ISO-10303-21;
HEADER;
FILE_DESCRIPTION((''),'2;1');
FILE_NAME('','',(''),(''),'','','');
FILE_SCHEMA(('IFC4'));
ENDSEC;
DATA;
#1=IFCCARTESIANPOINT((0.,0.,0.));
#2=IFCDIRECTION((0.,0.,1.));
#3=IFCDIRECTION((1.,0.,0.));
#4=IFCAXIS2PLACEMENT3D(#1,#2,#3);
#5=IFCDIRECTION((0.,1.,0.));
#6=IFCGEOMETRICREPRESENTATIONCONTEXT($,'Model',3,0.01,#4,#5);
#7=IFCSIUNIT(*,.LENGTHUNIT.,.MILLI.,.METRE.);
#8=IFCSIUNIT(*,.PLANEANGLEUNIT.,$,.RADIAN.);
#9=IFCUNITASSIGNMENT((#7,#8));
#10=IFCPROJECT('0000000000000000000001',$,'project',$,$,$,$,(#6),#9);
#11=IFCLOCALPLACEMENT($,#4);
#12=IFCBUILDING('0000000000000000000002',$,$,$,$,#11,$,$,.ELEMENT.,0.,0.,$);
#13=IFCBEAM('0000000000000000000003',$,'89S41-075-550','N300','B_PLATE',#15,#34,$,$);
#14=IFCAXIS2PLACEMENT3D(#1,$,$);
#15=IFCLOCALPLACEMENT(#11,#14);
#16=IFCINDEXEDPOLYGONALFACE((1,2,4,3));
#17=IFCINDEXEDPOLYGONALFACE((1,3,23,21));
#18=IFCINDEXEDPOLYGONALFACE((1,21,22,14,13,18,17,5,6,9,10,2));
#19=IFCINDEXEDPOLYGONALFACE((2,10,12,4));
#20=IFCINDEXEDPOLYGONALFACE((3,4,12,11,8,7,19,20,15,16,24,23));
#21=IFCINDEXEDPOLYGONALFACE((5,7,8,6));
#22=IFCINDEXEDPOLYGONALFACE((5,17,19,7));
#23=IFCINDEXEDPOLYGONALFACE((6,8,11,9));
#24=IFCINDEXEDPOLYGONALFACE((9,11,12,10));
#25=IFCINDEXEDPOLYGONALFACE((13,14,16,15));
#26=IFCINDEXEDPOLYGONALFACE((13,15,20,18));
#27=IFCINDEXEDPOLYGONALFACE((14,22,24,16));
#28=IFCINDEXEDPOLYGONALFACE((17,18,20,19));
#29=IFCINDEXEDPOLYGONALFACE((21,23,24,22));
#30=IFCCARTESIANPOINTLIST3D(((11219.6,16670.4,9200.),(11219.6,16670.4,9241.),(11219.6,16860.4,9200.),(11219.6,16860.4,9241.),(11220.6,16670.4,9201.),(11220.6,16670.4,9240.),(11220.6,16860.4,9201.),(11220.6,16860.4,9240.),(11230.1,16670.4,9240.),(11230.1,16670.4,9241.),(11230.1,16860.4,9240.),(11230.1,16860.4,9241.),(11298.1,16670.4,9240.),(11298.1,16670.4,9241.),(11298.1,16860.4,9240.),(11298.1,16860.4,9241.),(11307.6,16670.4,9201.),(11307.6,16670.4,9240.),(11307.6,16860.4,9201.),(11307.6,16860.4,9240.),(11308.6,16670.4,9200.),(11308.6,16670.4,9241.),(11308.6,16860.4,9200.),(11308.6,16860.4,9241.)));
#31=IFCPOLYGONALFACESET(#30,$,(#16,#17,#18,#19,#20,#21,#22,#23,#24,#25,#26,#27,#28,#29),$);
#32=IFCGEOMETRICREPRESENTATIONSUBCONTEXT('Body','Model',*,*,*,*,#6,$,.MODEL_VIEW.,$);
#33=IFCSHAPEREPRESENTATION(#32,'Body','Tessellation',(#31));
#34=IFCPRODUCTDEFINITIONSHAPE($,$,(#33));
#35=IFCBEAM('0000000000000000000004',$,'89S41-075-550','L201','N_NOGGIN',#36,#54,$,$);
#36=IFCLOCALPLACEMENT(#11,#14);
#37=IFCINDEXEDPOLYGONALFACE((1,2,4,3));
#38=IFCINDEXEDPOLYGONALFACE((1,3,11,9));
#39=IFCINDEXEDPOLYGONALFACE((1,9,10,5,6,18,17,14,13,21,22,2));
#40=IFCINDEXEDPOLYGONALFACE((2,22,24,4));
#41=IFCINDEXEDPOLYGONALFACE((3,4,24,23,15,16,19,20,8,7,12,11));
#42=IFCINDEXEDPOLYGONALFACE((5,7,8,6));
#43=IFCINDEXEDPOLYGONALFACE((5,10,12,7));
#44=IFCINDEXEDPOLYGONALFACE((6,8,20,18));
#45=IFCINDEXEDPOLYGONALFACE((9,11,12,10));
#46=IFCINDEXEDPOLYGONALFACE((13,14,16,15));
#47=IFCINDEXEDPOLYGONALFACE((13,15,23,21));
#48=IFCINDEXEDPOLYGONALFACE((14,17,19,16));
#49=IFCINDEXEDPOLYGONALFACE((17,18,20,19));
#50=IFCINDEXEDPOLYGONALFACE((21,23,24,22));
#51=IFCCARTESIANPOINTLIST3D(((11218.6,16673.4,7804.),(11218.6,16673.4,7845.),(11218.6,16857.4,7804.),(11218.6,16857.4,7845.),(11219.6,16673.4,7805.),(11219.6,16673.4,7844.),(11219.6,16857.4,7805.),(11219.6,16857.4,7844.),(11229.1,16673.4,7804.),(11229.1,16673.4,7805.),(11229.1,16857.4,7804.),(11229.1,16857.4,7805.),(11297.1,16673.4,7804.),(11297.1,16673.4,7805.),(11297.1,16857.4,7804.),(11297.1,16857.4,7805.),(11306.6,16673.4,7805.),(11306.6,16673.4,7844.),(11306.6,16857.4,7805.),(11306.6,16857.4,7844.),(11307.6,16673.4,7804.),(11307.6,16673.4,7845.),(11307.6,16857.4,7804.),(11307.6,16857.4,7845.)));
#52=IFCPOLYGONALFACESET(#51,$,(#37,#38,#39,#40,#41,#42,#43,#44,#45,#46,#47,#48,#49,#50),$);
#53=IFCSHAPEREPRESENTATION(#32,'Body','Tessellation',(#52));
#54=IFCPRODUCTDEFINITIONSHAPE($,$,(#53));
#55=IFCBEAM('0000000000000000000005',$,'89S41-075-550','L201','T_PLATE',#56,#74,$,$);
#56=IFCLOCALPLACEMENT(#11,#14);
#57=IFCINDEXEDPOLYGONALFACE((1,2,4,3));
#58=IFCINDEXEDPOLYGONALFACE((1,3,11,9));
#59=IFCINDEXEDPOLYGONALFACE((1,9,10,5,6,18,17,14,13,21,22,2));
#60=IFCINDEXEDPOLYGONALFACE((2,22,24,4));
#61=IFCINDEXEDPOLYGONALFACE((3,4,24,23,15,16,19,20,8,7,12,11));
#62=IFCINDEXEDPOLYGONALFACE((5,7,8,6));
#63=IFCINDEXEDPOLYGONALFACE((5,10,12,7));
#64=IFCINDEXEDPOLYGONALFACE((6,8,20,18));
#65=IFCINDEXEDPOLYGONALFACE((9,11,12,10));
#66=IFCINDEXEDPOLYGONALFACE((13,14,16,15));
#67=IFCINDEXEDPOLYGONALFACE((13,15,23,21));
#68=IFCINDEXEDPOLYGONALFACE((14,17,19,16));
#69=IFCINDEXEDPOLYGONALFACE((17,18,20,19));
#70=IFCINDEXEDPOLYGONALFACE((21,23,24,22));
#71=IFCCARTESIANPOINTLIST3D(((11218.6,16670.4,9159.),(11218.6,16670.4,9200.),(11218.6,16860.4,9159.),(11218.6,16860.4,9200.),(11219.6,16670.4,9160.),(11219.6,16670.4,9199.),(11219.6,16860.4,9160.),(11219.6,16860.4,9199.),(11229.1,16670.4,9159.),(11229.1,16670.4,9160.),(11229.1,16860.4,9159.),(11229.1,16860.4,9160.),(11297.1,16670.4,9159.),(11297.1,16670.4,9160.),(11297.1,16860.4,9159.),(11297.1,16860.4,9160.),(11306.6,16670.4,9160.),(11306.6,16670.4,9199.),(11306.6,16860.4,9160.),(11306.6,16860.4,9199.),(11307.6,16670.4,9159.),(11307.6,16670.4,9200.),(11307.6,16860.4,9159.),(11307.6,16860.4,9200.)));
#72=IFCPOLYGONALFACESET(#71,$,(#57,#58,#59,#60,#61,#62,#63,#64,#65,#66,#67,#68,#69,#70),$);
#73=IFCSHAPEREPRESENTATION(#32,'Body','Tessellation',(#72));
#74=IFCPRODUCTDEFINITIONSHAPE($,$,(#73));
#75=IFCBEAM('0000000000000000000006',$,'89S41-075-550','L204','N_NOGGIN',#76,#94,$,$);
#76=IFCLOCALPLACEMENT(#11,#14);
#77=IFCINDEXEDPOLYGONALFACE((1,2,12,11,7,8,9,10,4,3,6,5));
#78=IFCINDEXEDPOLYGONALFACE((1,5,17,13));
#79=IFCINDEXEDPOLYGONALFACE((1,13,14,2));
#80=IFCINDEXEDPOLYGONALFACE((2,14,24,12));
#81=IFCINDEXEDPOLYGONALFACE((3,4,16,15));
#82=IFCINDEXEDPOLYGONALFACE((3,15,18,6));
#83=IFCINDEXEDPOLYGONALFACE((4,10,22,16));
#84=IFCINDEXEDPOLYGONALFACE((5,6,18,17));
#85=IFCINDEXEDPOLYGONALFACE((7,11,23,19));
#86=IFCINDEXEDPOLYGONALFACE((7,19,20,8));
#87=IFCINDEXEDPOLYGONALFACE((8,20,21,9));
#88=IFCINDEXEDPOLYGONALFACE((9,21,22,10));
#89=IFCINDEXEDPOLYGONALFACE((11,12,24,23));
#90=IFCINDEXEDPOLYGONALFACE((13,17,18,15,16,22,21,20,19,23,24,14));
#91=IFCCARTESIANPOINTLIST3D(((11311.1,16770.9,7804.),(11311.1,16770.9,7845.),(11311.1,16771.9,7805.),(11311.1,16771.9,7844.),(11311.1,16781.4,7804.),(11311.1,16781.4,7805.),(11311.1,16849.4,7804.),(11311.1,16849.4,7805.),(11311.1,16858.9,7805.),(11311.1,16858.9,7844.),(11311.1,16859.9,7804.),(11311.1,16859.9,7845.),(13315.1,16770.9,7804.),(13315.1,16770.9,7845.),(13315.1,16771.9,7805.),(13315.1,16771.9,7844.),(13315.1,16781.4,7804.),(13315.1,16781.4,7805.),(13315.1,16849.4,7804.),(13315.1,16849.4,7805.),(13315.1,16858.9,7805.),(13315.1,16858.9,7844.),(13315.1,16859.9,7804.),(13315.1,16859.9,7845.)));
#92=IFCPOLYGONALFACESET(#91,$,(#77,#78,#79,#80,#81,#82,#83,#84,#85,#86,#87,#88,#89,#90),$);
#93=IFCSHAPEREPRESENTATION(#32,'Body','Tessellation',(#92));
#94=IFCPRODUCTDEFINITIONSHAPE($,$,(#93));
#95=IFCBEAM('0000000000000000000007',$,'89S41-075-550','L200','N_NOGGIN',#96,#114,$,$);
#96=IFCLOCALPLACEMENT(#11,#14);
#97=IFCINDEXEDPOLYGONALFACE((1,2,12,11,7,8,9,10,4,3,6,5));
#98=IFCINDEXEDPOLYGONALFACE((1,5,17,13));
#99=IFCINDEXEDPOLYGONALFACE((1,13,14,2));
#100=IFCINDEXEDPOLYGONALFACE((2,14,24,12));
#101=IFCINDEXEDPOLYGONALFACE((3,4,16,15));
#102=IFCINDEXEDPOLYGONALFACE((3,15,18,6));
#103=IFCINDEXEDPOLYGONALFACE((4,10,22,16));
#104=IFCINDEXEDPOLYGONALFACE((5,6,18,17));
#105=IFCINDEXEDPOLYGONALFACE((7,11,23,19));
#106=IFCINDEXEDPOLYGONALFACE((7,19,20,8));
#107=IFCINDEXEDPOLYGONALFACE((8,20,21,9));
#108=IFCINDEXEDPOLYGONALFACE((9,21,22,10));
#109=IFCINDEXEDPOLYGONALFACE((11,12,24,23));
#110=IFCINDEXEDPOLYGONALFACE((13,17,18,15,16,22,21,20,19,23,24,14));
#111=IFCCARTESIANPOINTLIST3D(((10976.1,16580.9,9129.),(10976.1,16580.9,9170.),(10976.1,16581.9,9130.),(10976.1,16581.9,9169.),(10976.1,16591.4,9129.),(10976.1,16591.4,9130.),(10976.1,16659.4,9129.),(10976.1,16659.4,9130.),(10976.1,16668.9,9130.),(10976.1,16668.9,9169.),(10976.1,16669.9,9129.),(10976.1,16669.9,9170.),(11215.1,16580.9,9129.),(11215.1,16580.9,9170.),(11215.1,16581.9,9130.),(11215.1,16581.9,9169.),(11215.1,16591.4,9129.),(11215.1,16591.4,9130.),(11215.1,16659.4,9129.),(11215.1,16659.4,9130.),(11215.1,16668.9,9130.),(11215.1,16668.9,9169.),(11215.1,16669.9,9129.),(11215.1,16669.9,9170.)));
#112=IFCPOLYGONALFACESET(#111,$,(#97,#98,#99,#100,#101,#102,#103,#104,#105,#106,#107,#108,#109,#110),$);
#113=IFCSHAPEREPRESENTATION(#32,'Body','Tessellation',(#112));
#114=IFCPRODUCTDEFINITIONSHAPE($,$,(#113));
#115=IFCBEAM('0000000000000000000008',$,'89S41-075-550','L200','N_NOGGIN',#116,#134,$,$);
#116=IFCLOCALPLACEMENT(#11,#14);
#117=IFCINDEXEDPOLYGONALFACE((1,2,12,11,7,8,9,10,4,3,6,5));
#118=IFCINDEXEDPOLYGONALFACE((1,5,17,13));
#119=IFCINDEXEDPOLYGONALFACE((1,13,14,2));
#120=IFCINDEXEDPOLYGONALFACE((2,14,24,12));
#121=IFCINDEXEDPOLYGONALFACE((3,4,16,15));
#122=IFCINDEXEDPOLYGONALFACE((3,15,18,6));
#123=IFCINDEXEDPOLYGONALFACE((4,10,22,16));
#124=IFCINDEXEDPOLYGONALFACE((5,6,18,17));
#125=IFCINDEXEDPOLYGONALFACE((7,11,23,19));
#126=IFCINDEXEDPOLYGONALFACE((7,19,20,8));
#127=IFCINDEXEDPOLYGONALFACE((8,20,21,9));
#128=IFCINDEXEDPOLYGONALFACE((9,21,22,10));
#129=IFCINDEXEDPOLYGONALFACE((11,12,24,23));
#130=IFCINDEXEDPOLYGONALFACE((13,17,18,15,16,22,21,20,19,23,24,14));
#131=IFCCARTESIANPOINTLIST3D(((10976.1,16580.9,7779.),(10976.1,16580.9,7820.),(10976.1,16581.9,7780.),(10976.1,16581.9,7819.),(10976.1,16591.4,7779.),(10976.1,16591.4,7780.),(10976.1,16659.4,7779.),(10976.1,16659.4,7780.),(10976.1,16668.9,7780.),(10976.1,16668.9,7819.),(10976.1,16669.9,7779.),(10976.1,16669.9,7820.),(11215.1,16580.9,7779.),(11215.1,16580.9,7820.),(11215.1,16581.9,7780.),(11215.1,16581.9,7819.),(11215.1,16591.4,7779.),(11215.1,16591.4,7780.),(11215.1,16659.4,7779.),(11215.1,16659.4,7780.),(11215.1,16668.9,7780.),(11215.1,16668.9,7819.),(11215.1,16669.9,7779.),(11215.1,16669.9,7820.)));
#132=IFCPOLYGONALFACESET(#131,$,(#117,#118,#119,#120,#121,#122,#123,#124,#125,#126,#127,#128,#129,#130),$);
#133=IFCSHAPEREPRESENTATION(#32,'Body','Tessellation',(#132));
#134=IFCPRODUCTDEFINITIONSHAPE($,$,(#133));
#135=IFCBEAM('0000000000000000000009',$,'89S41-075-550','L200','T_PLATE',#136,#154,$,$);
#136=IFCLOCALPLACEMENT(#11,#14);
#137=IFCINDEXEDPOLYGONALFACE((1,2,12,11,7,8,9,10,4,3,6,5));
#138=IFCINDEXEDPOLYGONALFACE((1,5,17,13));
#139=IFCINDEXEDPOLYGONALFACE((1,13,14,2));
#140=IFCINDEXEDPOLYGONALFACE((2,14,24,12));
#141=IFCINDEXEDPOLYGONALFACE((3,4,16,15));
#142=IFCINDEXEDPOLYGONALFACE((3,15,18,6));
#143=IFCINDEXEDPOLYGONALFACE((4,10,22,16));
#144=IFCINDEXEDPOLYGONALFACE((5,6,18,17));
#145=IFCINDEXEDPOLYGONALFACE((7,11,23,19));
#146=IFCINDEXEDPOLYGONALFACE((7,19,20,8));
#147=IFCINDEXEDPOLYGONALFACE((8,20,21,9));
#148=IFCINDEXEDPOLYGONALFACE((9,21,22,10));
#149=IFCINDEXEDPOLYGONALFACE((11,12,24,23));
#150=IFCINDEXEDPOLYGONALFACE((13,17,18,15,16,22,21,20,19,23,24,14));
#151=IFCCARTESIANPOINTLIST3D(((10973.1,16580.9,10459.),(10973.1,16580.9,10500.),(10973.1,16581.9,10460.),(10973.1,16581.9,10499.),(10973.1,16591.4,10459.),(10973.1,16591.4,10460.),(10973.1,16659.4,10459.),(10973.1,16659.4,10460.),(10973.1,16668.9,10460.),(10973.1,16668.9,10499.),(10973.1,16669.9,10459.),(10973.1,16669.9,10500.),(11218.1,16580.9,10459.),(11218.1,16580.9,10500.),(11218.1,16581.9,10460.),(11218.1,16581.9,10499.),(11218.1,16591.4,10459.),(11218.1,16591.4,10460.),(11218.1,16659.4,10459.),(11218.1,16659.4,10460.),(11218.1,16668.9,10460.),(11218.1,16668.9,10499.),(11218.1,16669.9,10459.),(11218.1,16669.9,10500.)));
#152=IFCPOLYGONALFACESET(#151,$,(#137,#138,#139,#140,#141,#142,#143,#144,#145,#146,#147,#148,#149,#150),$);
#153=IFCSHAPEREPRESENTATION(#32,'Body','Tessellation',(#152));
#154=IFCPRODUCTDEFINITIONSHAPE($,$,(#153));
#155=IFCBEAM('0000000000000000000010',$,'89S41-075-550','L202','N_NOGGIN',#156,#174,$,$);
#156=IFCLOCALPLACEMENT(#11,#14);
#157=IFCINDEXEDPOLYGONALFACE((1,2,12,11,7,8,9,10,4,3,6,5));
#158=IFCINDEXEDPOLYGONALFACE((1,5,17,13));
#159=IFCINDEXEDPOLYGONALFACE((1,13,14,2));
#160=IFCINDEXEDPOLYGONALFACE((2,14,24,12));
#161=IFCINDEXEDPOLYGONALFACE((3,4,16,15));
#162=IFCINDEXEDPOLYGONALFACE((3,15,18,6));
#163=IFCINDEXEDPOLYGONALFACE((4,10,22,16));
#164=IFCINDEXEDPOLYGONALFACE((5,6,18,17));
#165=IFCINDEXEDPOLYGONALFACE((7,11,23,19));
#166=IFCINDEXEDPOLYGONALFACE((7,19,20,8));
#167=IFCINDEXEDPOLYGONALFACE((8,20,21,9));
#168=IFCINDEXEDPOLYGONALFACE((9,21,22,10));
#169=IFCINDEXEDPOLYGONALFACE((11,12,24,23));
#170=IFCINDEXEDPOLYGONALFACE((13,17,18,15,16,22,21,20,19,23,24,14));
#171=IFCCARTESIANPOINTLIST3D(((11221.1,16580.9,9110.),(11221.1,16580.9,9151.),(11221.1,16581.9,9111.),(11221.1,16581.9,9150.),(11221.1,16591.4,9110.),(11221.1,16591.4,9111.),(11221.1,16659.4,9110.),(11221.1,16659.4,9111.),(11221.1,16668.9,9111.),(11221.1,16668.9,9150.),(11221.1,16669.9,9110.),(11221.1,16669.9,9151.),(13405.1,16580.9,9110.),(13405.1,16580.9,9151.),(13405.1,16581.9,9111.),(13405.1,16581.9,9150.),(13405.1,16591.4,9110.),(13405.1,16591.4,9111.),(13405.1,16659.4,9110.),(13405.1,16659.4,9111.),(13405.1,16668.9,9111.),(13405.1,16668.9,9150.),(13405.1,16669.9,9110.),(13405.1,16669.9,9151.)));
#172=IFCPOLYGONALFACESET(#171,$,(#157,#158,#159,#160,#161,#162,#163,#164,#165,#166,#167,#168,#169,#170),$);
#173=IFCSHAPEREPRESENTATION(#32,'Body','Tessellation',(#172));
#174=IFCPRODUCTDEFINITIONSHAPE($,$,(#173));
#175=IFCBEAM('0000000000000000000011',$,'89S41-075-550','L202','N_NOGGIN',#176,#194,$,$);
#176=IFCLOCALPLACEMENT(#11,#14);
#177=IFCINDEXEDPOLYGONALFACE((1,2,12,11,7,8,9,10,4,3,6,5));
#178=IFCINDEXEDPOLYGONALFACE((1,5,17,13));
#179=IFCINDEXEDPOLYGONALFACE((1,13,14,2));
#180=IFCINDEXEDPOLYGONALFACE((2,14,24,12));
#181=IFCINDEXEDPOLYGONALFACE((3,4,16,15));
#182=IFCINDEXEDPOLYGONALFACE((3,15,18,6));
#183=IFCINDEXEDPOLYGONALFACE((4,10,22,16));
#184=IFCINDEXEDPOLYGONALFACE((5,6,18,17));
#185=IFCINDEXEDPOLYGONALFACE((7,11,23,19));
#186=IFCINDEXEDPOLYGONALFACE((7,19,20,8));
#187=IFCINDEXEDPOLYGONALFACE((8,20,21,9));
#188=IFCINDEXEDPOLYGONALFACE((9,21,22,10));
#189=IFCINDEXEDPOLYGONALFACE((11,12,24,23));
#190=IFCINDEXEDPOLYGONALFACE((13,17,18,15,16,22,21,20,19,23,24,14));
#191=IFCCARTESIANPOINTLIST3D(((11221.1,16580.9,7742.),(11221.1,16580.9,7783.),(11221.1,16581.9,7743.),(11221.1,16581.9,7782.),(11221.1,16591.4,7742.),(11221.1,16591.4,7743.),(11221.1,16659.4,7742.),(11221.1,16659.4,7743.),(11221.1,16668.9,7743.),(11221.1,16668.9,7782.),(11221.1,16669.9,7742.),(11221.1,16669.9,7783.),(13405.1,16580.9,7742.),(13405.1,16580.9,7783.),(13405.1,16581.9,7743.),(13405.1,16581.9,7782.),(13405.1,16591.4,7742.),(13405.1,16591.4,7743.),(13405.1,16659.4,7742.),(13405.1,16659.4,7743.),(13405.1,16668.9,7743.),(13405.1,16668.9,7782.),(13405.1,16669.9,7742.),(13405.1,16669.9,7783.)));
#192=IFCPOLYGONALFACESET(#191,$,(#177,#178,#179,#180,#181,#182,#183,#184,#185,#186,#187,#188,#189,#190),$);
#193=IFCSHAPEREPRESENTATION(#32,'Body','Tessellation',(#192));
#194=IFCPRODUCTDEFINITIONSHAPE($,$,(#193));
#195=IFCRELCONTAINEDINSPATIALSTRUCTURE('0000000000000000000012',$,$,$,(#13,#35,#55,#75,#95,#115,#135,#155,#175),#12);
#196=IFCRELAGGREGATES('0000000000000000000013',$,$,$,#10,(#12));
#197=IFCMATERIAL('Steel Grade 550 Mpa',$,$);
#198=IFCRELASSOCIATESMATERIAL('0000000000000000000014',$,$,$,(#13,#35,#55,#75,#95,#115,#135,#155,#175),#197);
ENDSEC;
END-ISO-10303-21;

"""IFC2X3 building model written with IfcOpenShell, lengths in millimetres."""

from ifc_helpers import new_model, si_unit, direction, frame, origin, origin_with_axes, origin_2d_with_axis, place, context, subcontext, project, spatial, c_section, extrude, source, transform, mapped, material, element, save


model = new_model("IFC2X3")

# Units and contexts
model_context = context("Model", 3, precision=0.01, world=origin_with_axes(), true_north=direction((0.0, 1.0, 0.0)))
body_context = subcontext(model_context, "Body", "Model", "MODEL_VIEW")
ifc_project = project(units=[si_unit("LENGTHUNIT", "METRE", prefix="MILLI"), si_unit("PLANEANGLEUNIT", "RADIAN")], contexts=[model_context])

# Building
building_placement = place(None, origin_with_axes())
building = spatial("IfcBuilding", under=ifc_project, at=building_placement, CompositionType="ELEMENT", ElevationOfRefHeight=0.0, ElevationOfTerrain=0.0)

# Shared definitions
ifc_material_1 = material(Name="Steel Grade 550 Mpa")

# Beams
shared_shape_1 = source(origin(), body_context, "Body", "SweptSolid", [
    extrude(c_section(Depth=89.0, Width=41.0, WallThickness=1.0, Girth=10.5, at=origin_2d_with_axis()), origin_with_axes(), (0.0, 0.0, 1.0), 190.0),
])
beam_1_placement = place(None, frame((11264.1, 16860.4, 9220.5), z_axis=(0.0, -1.0, 0.0), x_axis=(0.0, 0.0, 1.0)))
element("IfcBeam", 1, at=beam_1_placement, inside=building, material=ifc_material_1, Name="89S41-075-550", Description="N300", ObjectType="B_PLATE", context=body_context, shape_type="MappedRepresentation", body=[
    mapped(shared_shape_1, transform((0.0, 0.0, 0.0), scale=1.0)),
])
shared_shape_2 = source(origin(), body_context, "Body", "SweptSolid", [
    extrude(c_section(Depth=89.0, Width=41.0, WallThickness=1.0, Girth=10.5, at=origin_2d_with_axis()), origin_with_axes(), (0.0, 0.0, 1.0), 184.0),
])
beam_2_placement = place(None, frame((11263.1, 16857.4, 7824.5), z_axis=(0.0, -1.0, 0.0), x_axis=(0.0, 0.0, -1.0)))
element("IfcBeam", 2, at=beam_2_placement, inside=building, material=ifc_material_1, Name="89S41-075-550", Description="L201", ObjectType="N_NOGGIN", context=body_context, shape_type="MappedRepresentation", body=[
    mapped(shared_shape_2, transform((0.0, 0.0, 0.0), scale=1.0)),
])
shared_shape_3 = source(origin(), body_context, "Body", "SweptSolid", [
    extrude(c_section(Depth=89.0, Width=41.0, WallThickness=1.0, Girth=10.5, at=origin_2d_with_axis()), origin_with_axes(), (0.0, 0.0, 1.0), 190.0),
])
beam_3_placement = place(None, frame((11263.1, 16860.4, 9179.5), z_axis=(0.0, -1.0, 0.0), x_axis=(0.0, 0.0, -1.0)))
element("IfcBeam", 3, at=beam_3_placement, inside=building, material=ifc_material_1, Name="89S41-075-550", Description="L201", ObjectType="T_PLATE", context=body_context, shape_type="MappedRepresentation", body=[
    mapped(shared_shape_3, transform((0.0, 0.0, 0.0), scale=1.0)),
])
shared_shape_4 = source(origin(), body_context, "Body", "SweptSolid", [
    extrude(c_section(Depth=89.0, Width=41.0, WallThickness=1.0, Girth=10.5, at=origin_2d_with_axis()), origin_with_axes(), (0.0, 0.0, 1.0), 2004.0),
])
beam_4_placement = place(None, frame((13315.1, 16815.4, 7824.5), z_axis=(-1.0, 0.0, 0.0), x_axis=(0.0, 0.0, -1.0)))
element("IfcBeam", 4, at=beam_4_placement, inside=building, material=ifc_material_1, Name="89S41-075-550", Description="L204", ObjectType="N_NOGGIN", context=body_context, shape_type="MappedRepresentation", body=[
    mapped(shared_shape_4, transform((0.0, 0.0, 0.0), scale=1.0)),
])
shared_shape_5 = source(origin(), body_context, "Body", "SweptSolid", [
    extrude(c_section(Depth=89.0, Width=41.0, WallThickness=1.0, Girth=10.5, at=origin_2d_with_axis()), origin_with_axes(), (0.0, 0.0, 1.0), 239.0),
])
beam_5_placement = place(None, frame((10976.1, 16625.4, 9149.5), z_axis=(1.0, 0.0, 0.0), x_axis=(0.0, 0.0, -1.0)))
element("IfcBeam", 5, at=beam_5_placement, inside=building, material=ifc_material_1, Name="89S41-075-550", Description="L200", ObjectType="N_NOGGIN", context=body_context, shape_type="MappedRepresentation", body=[
    mapped(shared_shape_5, transform((0.0, 0.0, 0.0), scale=1.0)),
])
shared_shape_6 = source(origin(), body_context, "Body", "SweptSolid", [
    extrude(c_section(Depth=89.0, Width=41.0, WallThickness=1.0, Girth=10.5, at=origin_2d_with_axis()), origin_with_axes(), (0.0, 0.0, 1.0), 239.0),
])
beam_6_placement = place(None, frame((10976.1, 16625.4, 7799.5), z_axis=(1.0, 0.0, 0.0), x_axis=(0.0, 0.0, -1.0)))
element("IfcBeam", 6, at=beam_6_placement, inside=building, material=ifc_material_1, Name="89S41-075-550", Description="L200", ObjectType="N_NOGGIN", context=body_context, shape_type="MappedRepresentation", body=[
    mapped(shared_shape_6, transform((0.0, 0.0, 0.0), scale=1.0)),
])
shared_shape_7 = source(origin(), body_context, "Body", "SweptSolid", [
    extrude(c_section(Depth=89.0, Width=41.0, WallThickness=1.0, Girth=10.5, at=origin_2d_with_axis()), origin_with_axes(), (0.0, 0.0, 1.0), 245.0),
])
beam_7_placement = place(None, frame((10973.1, 16625.4, 10479.5), z_axis=(1.0, 0.0, 0.0), x_axis=(0.0, 0.0, -1.0)))
element("IfcBeam", 7, at=beam_7_placement, inside=building, material=ifc_material_1, Name="89S41-075-550", Description="L200", ObjectType="T_PLATE", context=body_context, shape_type="MappedRepresentation", body=[
    mapped(shared_shape_7, transform((0.0, 0.0, 0.0), scale=1.0)),
])
shared_shape_8 = source(origin(), body_context, "Body", "SweptSolid", [
    extrude(c_section(Depth=89.0, Width=41.0, WallThickness=1.0, Girth=10.5, at=origin_2d_with_axis()), origin_with_axes(), (0.0, 0.0, 1.0), 2184.0),
])
beam_8_placement = place(None, frame((11221.1, 16625.4, 9130.5), z_axis=(1.0, 0.0, 0.0), x_axis=(0.0, 0.0, -1.0)))
element("IfcBeam", 8, at=beam_8_placement, inside=building, material=ifc_material_1, Name="89S41-075-550", Description="L202", ObjectType="N_NOGGIN", context=body_context, shape_type="MappedRepresentation", body=[
    mapped(shared_shape_8, transform((0.0, 0.0, 0.0), scale=1.0)),
])
shared_shape_9 = source(origin(), body_context, "Body", "SweptSolid", [
    extrude(c_section(Depth=89.0, Width=41.0, WallThickness=1.0, Girth=10.5, at=origin_2d_with_axis()), origin_with_axes(), (0.0, 0.0, 1.0), 2184.0),
])
beam_9_placement = place(None, frame((11221.1, 16625.4, 7762.5), z_axis=(1.0, 0.0, 0.0), x_axis=(0.0, 0.0, -1.0)))
element("IfcBeam", 9, at=beam_9_placement, inside=building, material=ifc_material_1, Name="89S41-075-550", Description="L202", ObjectType="N_NOGGIN", context=body_context, shape_type="MappedRepresentation", body=[
    mapped(shared_shape_9, transform((0.0, 0.0, 0.0), scale=1.0)),
])

save(model, "model.ifc")
